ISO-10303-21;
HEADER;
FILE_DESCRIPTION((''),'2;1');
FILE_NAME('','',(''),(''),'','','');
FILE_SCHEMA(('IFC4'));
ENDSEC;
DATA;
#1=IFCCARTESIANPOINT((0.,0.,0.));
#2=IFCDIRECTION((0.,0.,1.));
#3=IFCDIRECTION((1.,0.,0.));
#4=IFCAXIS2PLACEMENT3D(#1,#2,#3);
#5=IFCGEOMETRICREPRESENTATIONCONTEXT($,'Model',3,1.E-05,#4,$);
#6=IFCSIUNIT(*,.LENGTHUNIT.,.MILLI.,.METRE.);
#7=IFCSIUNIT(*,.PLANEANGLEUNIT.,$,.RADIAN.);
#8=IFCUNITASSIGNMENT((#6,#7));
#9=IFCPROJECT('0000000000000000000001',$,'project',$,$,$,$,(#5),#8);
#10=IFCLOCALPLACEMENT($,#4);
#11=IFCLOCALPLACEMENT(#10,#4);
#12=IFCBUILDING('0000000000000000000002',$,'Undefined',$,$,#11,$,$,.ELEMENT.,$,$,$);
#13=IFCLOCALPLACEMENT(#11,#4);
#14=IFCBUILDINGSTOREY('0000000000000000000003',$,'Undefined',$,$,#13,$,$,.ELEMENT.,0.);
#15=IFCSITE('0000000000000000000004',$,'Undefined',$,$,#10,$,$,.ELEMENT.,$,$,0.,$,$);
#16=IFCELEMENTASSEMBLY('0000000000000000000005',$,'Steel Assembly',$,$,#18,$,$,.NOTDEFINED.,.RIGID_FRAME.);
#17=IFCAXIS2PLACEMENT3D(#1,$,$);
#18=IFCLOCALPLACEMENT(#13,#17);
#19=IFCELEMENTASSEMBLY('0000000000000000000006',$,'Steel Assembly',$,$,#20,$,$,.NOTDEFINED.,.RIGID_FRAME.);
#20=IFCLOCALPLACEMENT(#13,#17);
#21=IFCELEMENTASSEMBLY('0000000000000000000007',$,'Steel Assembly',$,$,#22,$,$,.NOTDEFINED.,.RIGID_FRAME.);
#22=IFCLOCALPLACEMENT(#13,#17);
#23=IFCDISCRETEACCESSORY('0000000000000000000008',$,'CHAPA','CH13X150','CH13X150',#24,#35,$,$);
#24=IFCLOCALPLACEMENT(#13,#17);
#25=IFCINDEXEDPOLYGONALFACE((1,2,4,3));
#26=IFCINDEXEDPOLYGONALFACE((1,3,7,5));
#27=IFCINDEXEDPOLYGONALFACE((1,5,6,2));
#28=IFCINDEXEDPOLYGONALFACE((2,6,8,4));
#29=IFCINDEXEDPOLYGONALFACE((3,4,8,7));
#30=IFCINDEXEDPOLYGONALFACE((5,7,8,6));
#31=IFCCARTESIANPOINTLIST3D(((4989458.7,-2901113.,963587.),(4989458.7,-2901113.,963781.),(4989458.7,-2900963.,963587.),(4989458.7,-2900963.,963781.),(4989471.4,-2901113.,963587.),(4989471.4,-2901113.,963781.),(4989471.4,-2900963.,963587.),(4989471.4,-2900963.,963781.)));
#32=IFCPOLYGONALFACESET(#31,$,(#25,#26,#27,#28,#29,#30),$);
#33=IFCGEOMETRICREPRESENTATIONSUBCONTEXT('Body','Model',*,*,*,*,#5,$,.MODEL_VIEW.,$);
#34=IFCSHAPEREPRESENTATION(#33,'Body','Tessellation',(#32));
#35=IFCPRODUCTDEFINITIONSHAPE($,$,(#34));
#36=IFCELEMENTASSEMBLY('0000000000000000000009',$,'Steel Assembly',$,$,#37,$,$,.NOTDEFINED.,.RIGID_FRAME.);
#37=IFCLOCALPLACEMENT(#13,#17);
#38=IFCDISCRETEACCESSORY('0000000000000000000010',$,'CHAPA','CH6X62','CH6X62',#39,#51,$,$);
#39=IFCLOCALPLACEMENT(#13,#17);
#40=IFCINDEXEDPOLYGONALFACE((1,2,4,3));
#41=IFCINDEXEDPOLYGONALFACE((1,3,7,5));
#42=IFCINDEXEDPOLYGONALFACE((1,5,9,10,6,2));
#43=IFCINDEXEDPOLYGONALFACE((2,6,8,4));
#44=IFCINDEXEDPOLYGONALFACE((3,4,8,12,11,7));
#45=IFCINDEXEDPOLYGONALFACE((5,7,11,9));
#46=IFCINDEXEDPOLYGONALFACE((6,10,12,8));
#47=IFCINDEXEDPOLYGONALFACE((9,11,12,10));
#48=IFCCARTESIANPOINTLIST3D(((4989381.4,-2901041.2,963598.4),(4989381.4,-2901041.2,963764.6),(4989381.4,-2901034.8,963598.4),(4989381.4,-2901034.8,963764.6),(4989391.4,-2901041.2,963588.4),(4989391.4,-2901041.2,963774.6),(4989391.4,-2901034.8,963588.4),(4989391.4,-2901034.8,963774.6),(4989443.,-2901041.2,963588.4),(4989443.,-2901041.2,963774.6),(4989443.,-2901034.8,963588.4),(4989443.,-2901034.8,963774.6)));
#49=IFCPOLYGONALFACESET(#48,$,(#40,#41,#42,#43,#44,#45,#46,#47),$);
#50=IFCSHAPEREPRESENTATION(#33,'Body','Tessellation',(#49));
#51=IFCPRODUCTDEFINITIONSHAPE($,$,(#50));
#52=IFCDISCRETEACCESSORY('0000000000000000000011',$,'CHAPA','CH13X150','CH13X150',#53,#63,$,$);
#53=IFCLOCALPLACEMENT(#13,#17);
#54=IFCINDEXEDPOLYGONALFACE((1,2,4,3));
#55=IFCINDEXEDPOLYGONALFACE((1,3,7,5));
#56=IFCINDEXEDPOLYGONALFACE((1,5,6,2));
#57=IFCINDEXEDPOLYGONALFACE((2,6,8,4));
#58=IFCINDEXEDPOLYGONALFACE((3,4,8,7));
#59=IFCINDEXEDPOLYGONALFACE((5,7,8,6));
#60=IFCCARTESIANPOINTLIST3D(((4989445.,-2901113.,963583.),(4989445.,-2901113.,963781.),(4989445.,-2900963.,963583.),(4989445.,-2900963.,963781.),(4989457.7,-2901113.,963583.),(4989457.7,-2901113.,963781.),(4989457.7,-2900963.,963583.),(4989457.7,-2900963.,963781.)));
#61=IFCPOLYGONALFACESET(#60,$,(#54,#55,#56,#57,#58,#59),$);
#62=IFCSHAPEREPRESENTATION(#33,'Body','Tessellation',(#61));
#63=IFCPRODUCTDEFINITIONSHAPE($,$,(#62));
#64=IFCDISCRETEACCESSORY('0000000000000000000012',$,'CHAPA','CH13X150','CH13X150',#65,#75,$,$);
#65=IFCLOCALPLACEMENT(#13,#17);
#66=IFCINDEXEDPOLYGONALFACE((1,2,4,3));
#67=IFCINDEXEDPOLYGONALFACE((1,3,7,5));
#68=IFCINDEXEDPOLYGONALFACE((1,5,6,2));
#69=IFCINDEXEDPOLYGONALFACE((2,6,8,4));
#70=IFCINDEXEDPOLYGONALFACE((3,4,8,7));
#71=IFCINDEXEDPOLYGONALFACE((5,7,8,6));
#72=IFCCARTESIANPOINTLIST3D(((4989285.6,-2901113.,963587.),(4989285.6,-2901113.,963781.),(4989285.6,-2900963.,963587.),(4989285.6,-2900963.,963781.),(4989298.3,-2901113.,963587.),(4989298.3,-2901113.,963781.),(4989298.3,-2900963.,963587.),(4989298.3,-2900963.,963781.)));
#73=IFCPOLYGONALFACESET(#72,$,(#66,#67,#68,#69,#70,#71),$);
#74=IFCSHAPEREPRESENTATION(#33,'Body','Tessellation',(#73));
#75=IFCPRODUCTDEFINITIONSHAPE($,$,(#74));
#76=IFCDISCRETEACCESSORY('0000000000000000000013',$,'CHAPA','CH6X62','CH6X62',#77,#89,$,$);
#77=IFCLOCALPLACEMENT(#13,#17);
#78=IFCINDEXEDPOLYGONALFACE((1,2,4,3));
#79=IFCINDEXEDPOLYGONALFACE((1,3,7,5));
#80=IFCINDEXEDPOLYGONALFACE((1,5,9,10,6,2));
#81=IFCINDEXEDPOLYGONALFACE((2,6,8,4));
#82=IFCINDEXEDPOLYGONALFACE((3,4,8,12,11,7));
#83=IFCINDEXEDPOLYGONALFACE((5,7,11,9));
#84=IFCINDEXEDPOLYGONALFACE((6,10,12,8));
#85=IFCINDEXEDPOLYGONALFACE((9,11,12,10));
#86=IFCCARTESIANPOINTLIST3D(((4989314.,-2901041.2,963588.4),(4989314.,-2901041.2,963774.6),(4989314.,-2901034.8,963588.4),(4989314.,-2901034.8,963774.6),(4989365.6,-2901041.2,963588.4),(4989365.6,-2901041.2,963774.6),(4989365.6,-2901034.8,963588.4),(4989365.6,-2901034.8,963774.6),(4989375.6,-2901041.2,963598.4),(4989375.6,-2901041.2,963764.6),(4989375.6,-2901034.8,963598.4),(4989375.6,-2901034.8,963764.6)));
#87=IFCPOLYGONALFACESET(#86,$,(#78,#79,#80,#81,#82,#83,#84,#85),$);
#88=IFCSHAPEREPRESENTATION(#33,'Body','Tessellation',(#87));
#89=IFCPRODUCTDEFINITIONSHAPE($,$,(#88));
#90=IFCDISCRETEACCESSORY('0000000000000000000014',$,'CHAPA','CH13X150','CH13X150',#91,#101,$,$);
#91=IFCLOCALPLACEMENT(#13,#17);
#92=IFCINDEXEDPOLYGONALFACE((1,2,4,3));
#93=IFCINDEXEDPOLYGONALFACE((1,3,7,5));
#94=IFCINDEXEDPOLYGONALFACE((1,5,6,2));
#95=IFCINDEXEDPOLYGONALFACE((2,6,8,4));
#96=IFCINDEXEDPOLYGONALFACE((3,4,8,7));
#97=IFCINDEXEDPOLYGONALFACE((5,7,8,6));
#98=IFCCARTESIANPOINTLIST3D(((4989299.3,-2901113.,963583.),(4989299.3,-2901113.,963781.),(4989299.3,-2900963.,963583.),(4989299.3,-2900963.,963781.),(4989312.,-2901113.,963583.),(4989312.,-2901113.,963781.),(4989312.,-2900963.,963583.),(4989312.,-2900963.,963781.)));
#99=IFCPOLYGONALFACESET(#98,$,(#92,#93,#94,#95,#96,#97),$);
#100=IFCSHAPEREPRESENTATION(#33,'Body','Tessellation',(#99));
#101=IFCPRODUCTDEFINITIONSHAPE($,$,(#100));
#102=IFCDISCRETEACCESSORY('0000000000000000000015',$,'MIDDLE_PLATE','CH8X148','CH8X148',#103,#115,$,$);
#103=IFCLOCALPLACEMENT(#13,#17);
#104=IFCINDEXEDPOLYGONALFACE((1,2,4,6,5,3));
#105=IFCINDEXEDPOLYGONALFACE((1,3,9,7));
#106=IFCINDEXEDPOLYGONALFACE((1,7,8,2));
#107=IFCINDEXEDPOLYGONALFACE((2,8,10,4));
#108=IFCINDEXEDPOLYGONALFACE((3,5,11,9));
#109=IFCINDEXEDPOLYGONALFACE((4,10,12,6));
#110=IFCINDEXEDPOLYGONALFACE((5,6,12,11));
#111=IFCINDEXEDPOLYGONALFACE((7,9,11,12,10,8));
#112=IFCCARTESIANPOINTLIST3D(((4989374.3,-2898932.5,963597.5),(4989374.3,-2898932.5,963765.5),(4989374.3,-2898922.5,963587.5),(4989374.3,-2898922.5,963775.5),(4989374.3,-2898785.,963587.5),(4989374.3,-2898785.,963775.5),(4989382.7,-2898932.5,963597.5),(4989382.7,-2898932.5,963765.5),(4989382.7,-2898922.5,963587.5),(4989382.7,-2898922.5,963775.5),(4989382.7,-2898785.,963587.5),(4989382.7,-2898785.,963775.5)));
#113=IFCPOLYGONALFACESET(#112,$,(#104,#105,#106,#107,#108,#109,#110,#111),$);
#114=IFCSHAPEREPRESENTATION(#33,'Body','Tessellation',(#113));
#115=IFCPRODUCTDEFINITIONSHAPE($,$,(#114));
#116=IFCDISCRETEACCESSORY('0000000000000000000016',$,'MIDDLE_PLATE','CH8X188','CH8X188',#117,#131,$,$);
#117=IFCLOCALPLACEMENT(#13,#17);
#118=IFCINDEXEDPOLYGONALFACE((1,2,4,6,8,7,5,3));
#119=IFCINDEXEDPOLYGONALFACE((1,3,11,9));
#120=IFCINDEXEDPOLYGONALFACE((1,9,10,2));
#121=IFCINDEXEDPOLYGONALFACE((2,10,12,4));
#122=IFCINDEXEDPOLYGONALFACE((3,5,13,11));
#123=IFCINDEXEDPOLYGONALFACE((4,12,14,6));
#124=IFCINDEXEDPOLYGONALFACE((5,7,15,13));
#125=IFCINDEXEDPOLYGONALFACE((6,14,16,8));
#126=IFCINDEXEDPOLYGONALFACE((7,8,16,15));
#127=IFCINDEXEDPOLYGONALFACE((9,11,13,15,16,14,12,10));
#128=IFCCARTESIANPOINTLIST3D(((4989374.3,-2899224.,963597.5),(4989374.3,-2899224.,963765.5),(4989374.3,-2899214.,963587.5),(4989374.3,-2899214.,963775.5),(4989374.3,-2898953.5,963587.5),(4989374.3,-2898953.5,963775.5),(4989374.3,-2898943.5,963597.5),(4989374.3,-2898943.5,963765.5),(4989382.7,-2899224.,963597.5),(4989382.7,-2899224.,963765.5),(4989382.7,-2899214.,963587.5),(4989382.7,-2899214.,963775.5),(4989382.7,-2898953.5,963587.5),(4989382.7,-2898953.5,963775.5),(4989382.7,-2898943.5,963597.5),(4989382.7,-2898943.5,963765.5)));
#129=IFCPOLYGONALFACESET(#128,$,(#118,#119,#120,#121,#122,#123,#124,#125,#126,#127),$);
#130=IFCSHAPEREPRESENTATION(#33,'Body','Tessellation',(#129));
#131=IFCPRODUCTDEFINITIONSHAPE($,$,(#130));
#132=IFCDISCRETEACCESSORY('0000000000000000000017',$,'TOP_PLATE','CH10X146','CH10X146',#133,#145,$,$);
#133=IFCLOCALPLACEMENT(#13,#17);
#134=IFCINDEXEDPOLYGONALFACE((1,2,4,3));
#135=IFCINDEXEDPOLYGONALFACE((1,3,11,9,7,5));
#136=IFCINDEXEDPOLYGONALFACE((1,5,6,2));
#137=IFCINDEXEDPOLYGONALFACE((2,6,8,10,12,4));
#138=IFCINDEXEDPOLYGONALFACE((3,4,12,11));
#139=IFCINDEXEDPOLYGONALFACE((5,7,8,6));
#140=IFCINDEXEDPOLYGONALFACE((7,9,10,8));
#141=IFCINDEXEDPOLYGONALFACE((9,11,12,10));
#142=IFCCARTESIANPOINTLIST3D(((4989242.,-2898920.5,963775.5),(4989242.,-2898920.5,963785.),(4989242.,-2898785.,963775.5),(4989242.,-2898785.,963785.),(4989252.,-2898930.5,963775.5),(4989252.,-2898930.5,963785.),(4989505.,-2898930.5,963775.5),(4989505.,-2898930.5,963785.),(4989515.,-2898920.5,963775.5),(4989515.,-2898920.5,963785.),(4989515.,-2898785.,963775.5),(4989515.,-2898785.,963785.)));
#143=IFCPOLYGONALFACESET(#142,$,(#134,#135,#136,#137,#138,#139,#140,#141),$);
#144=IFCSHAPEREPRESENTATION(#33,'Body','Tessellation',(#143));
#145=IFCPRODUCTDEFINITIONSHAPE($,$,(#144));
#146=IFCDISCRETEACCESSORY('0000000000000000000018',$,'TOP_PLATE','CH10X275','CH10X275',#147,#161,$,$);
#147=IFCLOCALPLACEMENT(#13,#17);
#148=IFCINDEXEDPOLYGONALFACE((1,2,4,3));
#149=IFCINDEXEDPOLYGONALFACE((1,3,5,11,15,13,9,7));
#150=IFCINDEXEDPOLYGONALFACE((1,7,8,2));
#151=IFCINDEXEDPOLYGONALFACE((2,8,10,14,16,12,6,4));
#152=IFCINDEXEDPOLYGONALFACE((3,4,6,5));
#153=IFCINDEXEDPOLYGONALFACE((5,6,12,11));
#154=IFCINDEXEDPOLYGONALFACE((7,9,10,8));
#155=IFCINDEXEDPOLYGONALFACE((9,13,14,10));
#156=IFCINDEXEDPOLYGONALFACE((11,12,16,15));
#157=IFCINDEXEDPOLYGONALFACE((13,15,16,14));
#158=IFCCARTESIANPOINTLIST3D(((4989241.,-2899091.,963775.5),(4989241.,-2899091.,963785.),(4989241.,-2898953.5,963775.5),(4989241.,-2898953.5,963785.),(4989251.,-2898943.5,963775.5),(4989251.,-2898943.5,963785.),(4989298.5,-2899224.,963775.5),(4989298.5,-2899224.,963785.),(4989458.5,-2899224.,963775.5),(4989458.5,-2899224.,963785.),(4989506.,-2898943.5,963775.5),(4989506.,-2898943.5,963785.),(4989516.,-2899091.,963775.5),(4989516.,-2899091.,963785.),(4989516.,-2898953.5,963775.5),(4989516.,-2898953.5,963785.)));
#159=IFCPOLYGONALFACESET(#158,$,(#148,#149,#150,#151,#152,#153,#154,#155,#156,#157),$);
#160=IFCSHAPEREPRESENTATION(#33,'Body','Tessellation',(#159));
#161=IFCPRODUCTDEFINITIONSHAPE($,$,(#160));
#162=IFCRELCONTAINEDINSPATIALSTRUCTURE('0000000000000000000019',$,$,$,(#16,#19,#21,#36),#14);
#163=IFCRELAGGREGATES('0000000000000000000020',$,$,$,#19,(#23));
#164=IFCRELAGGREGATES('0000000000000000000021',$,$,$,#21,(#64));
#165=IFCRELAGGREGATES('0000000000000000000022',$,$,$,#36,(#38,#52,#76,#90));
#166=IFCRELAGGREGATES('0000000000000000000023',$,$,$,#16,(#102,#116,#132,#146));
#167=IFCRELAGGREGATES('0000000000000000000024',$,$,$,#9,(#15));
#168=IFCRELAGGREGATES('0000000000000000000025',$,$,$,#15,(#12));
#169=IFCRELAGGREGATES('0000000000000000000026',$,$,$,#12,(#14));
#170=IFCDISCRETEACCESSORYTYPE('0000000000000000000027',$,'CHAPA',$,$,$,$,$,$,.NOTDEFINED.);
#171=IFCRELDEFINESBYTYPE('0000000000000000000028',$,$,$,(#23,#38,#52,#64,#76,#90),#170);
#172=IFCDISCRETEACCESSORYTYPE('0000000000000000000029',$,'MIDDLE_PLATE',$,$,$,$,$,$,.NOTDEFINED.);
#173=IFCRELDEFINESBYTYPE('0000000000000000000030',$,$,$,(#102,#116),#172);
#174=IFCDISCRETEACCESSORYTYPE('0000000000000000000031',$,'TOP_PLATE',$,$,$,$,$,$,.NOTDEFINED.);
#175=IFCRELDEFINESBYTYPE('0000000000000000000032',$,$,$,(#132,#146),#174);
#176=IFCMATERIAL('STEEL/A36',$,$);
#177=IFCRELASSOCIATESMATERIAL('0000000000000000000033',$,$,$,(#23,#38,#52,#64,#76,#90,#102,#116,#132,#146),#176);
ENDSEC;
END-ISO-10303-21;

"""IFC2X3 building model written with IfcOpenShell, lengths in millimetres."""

from ifc_helpers import new_model, si_unit, frame, origin_with_axes, place, context, subcontext, project, spatial, polyline, outline, extrude, material, type_object, element, aggregate, save


model = new_model("IFC2X3")

# Units and contexts
model_context = context("Model", 3, precision=1e-05, world=origin_with_axes())
body_context = subcontext(model_context, "Body", "Model", "MODEL_VIEW")
ifc_project = project(units=[si_unit("LENGTHUNIT", "METRE", prefix="MILLI"), si_unit("PLANEANGLEUNIT", "RADIAN")], contexts=[model_context])

# Site, building, storey
site_placement = place(None, origin_with_axes())
site = spatial("IfcSite", under=ifc_project, at=site_placement, Name="Undefined", CompositionType="ELEMENT", RefElevation=0.0)
building_placement = place(site_placement, origin_with_axes())
building = spatial("IfcBuilding", under=site, at=building_placement, Name="Undefined", CompositionType="ELEMENT")
storey_placement = place(building_placement, origin_with_axes())
storey = spatial("IfcBuildingStorey", under=building, at=storey_placement, Name="Undefined", CompositionType="ELEMENT", Elevation=0.0)

# Shared definitions
ifc_material_1 = material(Name="STEEL/A36")
discrete_accessory_type_1 = type_object("IfcDiscreteAccessoryType", Name="CHAPA")

# Element assembly
assembly_1_placement = place(storey_placement, origin_with_axes())
assembly_1 = element("IfcElementAssembly", 1, at=assembly_1_placement, inside=storey, Name="Steel Assembly", AssemblyPlace="NOTDEFINED", PredefinedType="RIGID_FRAME")

# Element assembly
assembly_2_placement = place(storey_placement, origin_with_axes())
assembly_2 = element("IfcElementAssembly", 2, at=assembly_2_placement, inside=storey, Name="Steel Assembly", AssemblyPlace="NOTDEFINED", PredefinedType="RIGID_FRAME")

# Element assembly
assembly_3_placement = place(storey_placement, origin_with_axes())
assembly_3 = element("IfcElementAssembly", 3, at=assembly_3_placement, inside=storey, Name="Steel Assembly", AssemblyPlace="NOTDEFINED", PredefinedType="RIGID_FRAME")

# Discrete accessory
discrete_accessory_1_placement = place(assembly_2_placement, frame((4989465.0, -2901038.0, 963781.0), z_axis=(1.0, 0.0, 0.0), x_axis=(0.0, 0.0, -1.0)))
discrete_accessory_1 = element("IfcDiscreteAccessory", 4, at=discrete_accessory_1_placement, type_object=discrete_accessory_type_1, material=ifc_material_1, Name="CHAPA", Description="CH13X150", ObjectType="CH13X150", context=body_context, shape_type="SweptSolid", body=[
    extrude(outline(polyline([(194.0, -75.0), (0.0, -75.0), (0.0, 75.0), (194.0, 75.0), (194.0, -75.0)])), frame((0.0, 0.0, -6.3), z_axis=(0.0, 0.0, 1.0), x_axis=(1.0, 0.0, 0.0)), (0.0, 0.0, 1.0), 12.7),
])
aggregate(assembly_2, [discrete_accessory_1])

# Element assembly, discrete accessories
assembly_4_placement = place(storey_placement, origin_with_axes())
assembly_4 = element("IfcElementAssembly", 5, at=assembly_4_placement, inside=storey, Name="Steel Assembly", AssemblyPlace="NOTDEFINED", PredefinedType="RIGID_FRAME")
discrete_accessory_2_placement = place(assembly_4_placement, frame((4989381.4, -2901038.0, 963774.6), z_axis=(0.0, 1.0, 0.0), x_axis=(1.0, 0.0, 0.0)))
discrete_accessory_2 = element("IfcDiscreteAccessory", 6, at=discrete_accessory_2_placement, type_object=discrete_accessory_type_1, material=ifc_material_1, Name="CHAPA", Description="CH6X62", ObjectType="CH6X62", context=body_context, shape_type="SweptSolid", body=[
    extrude(outline(polyline([(0.0, 10.0), (10.0, 0.0), (61.6, 0.0), (61.6, 186.2), (10.0, 186.2), (0.0, 176.2), (0.0, 10.0)])), frame((0.0, 0.0, -3.2), z_axis=(0.0, 0.0, 1.0), x_axis=(1.0, 0.0, 0.0)), (0.0, 0.0, 1.0), 6.4),
])
discrete_accessory_3_placement = place(assembly_4_placement, frame((4989451.3, -2901038.0, 963781.0), z_axis=(1.0, 0.0, 0.0), x_axis=(0.0, 0.0, -1.0)))
discrete_accessory_3 = element("IfcDiscreteAccessory", 7, at=discrete_accessory_3_placement, type_object=discrete_accessory_type_1, material=ifc_material_1, Name="CHAPA", Description="CH13X150", ObjectType="CH13X150", context=body_context, shape_type="SweptSolid", body=[
    extrude(outline(polyline([(198.0, -75.0), (0.0, -75.0), (0.0, 75.0), (198.0, 75.0), (198.0, -75.0)])), frame((0.0, 0.0, -6.3), z_axis=(0.0, 0.0, 1.0), x_axis=(1.0, 0.0, 0.0)), (0.0, 0.0, 1.0), 12.7),
])

# Discrete accessories
discrete_accessory_4_placement = place(assembly_3_placement, frame((4989291.9, -2901038.0, 963781.0), z_axis=(-1.0, 0.0, 0.0), x_axis=(0.0, 0.0, -1.0)))
discrete_accessory_4 = element("IfcDiscreteAccessory", 8, at=discrete_accessory_4_placement, type_object=discrete_accessory_type_1, material=ifc_material_1, Name="CHAPA", Description="CH13X150", ObjectType="CH13X150", context=body_context, shape_type="SweptSolid", body=[
    extrude(outline(polyline([(194.0, 75.0), (194.0, -75.0), (0.0, -75.0), (0.0, 75.0), (194.0, 75.0)])), frame((0.0, 0.0, -6.3), z_axis=(0.0, 0.0, 1.0), x_axis=(1.0, 0.0, 0.0)), (0.0, 0.0, 1.0), 12.7),
])
aggregate(assembly_3, [discrete_accessory_4])
discrete_accessory_5_placement = place(assembly_4_placement, frame((4989375.6, -2901038.0, 963774.6), z_axis=(0.0, -1.0, 0.0), x_axis=(-1.0, 0.0, 0.0)))
discrete_accessory_5 = element("IfcDiscreteAccessory", 9, at=discrete_accessory_5_placement, type_object=discrete_accessory_type_1, material=ifc_material_1, Name="CHAPA", Description="CH6X62", ObjectType="CH6X62", context=body_context, shape_type="SweptSolid", body=[
    extrude(outline(polyline([(0.0, 10.0), (10.0, 0.0), (61.6, 0.0), (61.6, 186.2), (10.0, 186.2), (0.0, 176.2), (0.0, 10.0)])), frame((0.0, 0.0, -3.2), z_axis=(0.0, 0.0, 1.0), x_axis=(1.0, 0.0, 0.0)), (0.0, 0.0, 1.0), 6.4),
])
discrete_accessory_6_placement = place(assembly_4_placement, frame((4989305.6, -2901038.0, 963781.0), z_axis=(-1.0, 0.0, 0.0), x_axis=(0.0, 0.0, -1.0)))
discrete_accessory_6 = element("IfcDiscreteAccessory", 10, at=discrete_accessory_6_placement, type_object=discrete_accessory_type_1, material=ifc_material_1, Name="CHAPA", Description="CH13X150", ObjectType="CH13X150", context=body_context, shape_type="SweptSolid", body=[
    extrude(outline(polyline([(198.0, 75.0), (198.0, -75.0), (0.0, -75.0), (0.0, 75.0), (198.0, 75.0)])), frame((0.0, 0.0, -6.3), z_axis=(0.0, 0.0, 1.0), x_axis=(1.0, 0.0, 0.0)), (0.0, 0.0, 1.0), 12.7),
])
aggregate(assembly_4, [discrete_accessory_2, discrete_accessory_3, discrete_accessory_5, discrete_accessory_6])
discrete_accessory_type_2 = type_object("IfcDiscreteAccessoryType", Name="MIDDLE_PLATE")
discrete_accessory_7_placement = place(assembly_1_placement, frame((4989378.5, -2898932.5, 963775.5), z_axis=(-1.0, 0.0, 0.0), x_axis=(0.0, 1.0, 0.0)))
discrete_accessory_7 = element("IfcDiscreteAccessory", 11, at=discrete_accessory_7_placement, type_object=discrete_accessory_type_2, material=ifc_material_1, Name="MIDDLE_PLATE", Description="CH8X148", ObjectType="CH8X148", context=body_context, shape_type="SweptSolid", body=[
    extrude(outline(polyline([(0.0, 10.0), (10.0, 0.0), (147.5, 0.0), (147.5, 188.0), (10.0, 188.0), (0.0, 178.0), (0.0, 10.0)])), frame((0.0, 0.0, -4.2), z_axis=(0.0, 0.0, 1.0), x_axis=(1.0, 0.0, 0.0)), (0.0, 0.0, 1.0), 8.4),
])
discrete_accessory_8_placement = place(assembly_1_placement, frame((4989378.5, -2899224.0, 963775.5), z_axis=(-1.0, 0.0, 0.0), x_axis=(0.0, 1.0, 0.0)))
discrete_accessory_8 = element("IfcDiscreteAccessory", 12, at=discrete_accessory_8_placement, type_object=discrete_accessory_type_2, material=ifc_material_1, Name="MIDDLE_PLATE", Description="CH8X188", ObjectType="CH8X188", context=body_context, shape_type="SweptSolid", body=[
    extrude(outline(polyline([(0.0, 10.0), (10.0, 0.0), (270.5, 0.0), (280.5, 10.0), (280.5, 178.0), (270.5, 188.0), (10.0, 188.0), (0.0, 178.0), (0.0, 10.0)])), frame((0.0, 0.0, -4.2), z_axis=(0.0, 0.0, 1.0), x_axis=(1.0, 0.0, 0.0)), (0.0, 0.0, 1.0), 8.4),
])
discrete_accessory_type_3 = type_object("IfcDiscreteAccessoryType", Name="TOP_PLATE")
discrete_accessory_9_placement = place(assembly_1_placement, frame((4989515.0, -2898930.5, 963780.3), z_axis=(0.0, 0.0, 1.0), x_axis=(0.0, 1.0, 0.0)))
discrete_accessory_9 = element("IfcDiscreteAccessory", 13, at=discrete_accessory_9_placement, type_object=discrete_accessory_type_3, material=ifc_material_1, Name="TOP_PLATE", Description="CH10X146", ObjectType="CH10X146", context=body_context, shape_type="SweptSolid", body=[
    extrude(outline(polyline([(0.0, 10.0), (10.0, 0.0), (145.5, 0.0), (145.5, 273.0), (10.0, 273.0), (0.0, 263.0), (0.0, 10.0)])), frame((0.0, 0.0, -4.8), z_axis=(0.0, 0.0, 1.0), x_axis=(1.0, 0.0, 0.0)), (0.0, 0.0, 1.0), 9.5),
])
discrete_accessory_10_placement = place(assembly_1_placement, frame((4989516.0, -2899091.0, 963780.3), z_axis=(0.0, 0.0, 1.0), x_axis=(0.0, 1.0, 0.0)))
discrete_accessory_10 = element("IfcDiscreteAccessory", 14, at=discrete_accessory_10_placement, type_object=discrete_accessory_type_3, material=ifc_material_1, Name="TOP_PLATE", Description="CH10X275", ObjectType="CH10X275", context=body_context, shape_type="SweptSolid", body=[
    extrude(outline(polyline([(0.0, 0.0), (137.5, 0.0), (147.5, 10.0), (147.5, 265.0), (137.5, 275.0), (0.0, 275.0), (-133.0, 217.5), (-133.0, 57.5), (0.0, 0.0)])), frame((0.0, 0.0, -4.8), z_axis=(0.0, 0.0, 1.0), x_axis=(1.0, 0.0, 0.0)), (0.0, 0.0, 1.0), 9.5),
])
aggregate(assembly_1, [discrete_accessory_7, discrete_accessory_8, discrete_accessory_9, discrete_accessory_10])

save(model, "model.ifc")
